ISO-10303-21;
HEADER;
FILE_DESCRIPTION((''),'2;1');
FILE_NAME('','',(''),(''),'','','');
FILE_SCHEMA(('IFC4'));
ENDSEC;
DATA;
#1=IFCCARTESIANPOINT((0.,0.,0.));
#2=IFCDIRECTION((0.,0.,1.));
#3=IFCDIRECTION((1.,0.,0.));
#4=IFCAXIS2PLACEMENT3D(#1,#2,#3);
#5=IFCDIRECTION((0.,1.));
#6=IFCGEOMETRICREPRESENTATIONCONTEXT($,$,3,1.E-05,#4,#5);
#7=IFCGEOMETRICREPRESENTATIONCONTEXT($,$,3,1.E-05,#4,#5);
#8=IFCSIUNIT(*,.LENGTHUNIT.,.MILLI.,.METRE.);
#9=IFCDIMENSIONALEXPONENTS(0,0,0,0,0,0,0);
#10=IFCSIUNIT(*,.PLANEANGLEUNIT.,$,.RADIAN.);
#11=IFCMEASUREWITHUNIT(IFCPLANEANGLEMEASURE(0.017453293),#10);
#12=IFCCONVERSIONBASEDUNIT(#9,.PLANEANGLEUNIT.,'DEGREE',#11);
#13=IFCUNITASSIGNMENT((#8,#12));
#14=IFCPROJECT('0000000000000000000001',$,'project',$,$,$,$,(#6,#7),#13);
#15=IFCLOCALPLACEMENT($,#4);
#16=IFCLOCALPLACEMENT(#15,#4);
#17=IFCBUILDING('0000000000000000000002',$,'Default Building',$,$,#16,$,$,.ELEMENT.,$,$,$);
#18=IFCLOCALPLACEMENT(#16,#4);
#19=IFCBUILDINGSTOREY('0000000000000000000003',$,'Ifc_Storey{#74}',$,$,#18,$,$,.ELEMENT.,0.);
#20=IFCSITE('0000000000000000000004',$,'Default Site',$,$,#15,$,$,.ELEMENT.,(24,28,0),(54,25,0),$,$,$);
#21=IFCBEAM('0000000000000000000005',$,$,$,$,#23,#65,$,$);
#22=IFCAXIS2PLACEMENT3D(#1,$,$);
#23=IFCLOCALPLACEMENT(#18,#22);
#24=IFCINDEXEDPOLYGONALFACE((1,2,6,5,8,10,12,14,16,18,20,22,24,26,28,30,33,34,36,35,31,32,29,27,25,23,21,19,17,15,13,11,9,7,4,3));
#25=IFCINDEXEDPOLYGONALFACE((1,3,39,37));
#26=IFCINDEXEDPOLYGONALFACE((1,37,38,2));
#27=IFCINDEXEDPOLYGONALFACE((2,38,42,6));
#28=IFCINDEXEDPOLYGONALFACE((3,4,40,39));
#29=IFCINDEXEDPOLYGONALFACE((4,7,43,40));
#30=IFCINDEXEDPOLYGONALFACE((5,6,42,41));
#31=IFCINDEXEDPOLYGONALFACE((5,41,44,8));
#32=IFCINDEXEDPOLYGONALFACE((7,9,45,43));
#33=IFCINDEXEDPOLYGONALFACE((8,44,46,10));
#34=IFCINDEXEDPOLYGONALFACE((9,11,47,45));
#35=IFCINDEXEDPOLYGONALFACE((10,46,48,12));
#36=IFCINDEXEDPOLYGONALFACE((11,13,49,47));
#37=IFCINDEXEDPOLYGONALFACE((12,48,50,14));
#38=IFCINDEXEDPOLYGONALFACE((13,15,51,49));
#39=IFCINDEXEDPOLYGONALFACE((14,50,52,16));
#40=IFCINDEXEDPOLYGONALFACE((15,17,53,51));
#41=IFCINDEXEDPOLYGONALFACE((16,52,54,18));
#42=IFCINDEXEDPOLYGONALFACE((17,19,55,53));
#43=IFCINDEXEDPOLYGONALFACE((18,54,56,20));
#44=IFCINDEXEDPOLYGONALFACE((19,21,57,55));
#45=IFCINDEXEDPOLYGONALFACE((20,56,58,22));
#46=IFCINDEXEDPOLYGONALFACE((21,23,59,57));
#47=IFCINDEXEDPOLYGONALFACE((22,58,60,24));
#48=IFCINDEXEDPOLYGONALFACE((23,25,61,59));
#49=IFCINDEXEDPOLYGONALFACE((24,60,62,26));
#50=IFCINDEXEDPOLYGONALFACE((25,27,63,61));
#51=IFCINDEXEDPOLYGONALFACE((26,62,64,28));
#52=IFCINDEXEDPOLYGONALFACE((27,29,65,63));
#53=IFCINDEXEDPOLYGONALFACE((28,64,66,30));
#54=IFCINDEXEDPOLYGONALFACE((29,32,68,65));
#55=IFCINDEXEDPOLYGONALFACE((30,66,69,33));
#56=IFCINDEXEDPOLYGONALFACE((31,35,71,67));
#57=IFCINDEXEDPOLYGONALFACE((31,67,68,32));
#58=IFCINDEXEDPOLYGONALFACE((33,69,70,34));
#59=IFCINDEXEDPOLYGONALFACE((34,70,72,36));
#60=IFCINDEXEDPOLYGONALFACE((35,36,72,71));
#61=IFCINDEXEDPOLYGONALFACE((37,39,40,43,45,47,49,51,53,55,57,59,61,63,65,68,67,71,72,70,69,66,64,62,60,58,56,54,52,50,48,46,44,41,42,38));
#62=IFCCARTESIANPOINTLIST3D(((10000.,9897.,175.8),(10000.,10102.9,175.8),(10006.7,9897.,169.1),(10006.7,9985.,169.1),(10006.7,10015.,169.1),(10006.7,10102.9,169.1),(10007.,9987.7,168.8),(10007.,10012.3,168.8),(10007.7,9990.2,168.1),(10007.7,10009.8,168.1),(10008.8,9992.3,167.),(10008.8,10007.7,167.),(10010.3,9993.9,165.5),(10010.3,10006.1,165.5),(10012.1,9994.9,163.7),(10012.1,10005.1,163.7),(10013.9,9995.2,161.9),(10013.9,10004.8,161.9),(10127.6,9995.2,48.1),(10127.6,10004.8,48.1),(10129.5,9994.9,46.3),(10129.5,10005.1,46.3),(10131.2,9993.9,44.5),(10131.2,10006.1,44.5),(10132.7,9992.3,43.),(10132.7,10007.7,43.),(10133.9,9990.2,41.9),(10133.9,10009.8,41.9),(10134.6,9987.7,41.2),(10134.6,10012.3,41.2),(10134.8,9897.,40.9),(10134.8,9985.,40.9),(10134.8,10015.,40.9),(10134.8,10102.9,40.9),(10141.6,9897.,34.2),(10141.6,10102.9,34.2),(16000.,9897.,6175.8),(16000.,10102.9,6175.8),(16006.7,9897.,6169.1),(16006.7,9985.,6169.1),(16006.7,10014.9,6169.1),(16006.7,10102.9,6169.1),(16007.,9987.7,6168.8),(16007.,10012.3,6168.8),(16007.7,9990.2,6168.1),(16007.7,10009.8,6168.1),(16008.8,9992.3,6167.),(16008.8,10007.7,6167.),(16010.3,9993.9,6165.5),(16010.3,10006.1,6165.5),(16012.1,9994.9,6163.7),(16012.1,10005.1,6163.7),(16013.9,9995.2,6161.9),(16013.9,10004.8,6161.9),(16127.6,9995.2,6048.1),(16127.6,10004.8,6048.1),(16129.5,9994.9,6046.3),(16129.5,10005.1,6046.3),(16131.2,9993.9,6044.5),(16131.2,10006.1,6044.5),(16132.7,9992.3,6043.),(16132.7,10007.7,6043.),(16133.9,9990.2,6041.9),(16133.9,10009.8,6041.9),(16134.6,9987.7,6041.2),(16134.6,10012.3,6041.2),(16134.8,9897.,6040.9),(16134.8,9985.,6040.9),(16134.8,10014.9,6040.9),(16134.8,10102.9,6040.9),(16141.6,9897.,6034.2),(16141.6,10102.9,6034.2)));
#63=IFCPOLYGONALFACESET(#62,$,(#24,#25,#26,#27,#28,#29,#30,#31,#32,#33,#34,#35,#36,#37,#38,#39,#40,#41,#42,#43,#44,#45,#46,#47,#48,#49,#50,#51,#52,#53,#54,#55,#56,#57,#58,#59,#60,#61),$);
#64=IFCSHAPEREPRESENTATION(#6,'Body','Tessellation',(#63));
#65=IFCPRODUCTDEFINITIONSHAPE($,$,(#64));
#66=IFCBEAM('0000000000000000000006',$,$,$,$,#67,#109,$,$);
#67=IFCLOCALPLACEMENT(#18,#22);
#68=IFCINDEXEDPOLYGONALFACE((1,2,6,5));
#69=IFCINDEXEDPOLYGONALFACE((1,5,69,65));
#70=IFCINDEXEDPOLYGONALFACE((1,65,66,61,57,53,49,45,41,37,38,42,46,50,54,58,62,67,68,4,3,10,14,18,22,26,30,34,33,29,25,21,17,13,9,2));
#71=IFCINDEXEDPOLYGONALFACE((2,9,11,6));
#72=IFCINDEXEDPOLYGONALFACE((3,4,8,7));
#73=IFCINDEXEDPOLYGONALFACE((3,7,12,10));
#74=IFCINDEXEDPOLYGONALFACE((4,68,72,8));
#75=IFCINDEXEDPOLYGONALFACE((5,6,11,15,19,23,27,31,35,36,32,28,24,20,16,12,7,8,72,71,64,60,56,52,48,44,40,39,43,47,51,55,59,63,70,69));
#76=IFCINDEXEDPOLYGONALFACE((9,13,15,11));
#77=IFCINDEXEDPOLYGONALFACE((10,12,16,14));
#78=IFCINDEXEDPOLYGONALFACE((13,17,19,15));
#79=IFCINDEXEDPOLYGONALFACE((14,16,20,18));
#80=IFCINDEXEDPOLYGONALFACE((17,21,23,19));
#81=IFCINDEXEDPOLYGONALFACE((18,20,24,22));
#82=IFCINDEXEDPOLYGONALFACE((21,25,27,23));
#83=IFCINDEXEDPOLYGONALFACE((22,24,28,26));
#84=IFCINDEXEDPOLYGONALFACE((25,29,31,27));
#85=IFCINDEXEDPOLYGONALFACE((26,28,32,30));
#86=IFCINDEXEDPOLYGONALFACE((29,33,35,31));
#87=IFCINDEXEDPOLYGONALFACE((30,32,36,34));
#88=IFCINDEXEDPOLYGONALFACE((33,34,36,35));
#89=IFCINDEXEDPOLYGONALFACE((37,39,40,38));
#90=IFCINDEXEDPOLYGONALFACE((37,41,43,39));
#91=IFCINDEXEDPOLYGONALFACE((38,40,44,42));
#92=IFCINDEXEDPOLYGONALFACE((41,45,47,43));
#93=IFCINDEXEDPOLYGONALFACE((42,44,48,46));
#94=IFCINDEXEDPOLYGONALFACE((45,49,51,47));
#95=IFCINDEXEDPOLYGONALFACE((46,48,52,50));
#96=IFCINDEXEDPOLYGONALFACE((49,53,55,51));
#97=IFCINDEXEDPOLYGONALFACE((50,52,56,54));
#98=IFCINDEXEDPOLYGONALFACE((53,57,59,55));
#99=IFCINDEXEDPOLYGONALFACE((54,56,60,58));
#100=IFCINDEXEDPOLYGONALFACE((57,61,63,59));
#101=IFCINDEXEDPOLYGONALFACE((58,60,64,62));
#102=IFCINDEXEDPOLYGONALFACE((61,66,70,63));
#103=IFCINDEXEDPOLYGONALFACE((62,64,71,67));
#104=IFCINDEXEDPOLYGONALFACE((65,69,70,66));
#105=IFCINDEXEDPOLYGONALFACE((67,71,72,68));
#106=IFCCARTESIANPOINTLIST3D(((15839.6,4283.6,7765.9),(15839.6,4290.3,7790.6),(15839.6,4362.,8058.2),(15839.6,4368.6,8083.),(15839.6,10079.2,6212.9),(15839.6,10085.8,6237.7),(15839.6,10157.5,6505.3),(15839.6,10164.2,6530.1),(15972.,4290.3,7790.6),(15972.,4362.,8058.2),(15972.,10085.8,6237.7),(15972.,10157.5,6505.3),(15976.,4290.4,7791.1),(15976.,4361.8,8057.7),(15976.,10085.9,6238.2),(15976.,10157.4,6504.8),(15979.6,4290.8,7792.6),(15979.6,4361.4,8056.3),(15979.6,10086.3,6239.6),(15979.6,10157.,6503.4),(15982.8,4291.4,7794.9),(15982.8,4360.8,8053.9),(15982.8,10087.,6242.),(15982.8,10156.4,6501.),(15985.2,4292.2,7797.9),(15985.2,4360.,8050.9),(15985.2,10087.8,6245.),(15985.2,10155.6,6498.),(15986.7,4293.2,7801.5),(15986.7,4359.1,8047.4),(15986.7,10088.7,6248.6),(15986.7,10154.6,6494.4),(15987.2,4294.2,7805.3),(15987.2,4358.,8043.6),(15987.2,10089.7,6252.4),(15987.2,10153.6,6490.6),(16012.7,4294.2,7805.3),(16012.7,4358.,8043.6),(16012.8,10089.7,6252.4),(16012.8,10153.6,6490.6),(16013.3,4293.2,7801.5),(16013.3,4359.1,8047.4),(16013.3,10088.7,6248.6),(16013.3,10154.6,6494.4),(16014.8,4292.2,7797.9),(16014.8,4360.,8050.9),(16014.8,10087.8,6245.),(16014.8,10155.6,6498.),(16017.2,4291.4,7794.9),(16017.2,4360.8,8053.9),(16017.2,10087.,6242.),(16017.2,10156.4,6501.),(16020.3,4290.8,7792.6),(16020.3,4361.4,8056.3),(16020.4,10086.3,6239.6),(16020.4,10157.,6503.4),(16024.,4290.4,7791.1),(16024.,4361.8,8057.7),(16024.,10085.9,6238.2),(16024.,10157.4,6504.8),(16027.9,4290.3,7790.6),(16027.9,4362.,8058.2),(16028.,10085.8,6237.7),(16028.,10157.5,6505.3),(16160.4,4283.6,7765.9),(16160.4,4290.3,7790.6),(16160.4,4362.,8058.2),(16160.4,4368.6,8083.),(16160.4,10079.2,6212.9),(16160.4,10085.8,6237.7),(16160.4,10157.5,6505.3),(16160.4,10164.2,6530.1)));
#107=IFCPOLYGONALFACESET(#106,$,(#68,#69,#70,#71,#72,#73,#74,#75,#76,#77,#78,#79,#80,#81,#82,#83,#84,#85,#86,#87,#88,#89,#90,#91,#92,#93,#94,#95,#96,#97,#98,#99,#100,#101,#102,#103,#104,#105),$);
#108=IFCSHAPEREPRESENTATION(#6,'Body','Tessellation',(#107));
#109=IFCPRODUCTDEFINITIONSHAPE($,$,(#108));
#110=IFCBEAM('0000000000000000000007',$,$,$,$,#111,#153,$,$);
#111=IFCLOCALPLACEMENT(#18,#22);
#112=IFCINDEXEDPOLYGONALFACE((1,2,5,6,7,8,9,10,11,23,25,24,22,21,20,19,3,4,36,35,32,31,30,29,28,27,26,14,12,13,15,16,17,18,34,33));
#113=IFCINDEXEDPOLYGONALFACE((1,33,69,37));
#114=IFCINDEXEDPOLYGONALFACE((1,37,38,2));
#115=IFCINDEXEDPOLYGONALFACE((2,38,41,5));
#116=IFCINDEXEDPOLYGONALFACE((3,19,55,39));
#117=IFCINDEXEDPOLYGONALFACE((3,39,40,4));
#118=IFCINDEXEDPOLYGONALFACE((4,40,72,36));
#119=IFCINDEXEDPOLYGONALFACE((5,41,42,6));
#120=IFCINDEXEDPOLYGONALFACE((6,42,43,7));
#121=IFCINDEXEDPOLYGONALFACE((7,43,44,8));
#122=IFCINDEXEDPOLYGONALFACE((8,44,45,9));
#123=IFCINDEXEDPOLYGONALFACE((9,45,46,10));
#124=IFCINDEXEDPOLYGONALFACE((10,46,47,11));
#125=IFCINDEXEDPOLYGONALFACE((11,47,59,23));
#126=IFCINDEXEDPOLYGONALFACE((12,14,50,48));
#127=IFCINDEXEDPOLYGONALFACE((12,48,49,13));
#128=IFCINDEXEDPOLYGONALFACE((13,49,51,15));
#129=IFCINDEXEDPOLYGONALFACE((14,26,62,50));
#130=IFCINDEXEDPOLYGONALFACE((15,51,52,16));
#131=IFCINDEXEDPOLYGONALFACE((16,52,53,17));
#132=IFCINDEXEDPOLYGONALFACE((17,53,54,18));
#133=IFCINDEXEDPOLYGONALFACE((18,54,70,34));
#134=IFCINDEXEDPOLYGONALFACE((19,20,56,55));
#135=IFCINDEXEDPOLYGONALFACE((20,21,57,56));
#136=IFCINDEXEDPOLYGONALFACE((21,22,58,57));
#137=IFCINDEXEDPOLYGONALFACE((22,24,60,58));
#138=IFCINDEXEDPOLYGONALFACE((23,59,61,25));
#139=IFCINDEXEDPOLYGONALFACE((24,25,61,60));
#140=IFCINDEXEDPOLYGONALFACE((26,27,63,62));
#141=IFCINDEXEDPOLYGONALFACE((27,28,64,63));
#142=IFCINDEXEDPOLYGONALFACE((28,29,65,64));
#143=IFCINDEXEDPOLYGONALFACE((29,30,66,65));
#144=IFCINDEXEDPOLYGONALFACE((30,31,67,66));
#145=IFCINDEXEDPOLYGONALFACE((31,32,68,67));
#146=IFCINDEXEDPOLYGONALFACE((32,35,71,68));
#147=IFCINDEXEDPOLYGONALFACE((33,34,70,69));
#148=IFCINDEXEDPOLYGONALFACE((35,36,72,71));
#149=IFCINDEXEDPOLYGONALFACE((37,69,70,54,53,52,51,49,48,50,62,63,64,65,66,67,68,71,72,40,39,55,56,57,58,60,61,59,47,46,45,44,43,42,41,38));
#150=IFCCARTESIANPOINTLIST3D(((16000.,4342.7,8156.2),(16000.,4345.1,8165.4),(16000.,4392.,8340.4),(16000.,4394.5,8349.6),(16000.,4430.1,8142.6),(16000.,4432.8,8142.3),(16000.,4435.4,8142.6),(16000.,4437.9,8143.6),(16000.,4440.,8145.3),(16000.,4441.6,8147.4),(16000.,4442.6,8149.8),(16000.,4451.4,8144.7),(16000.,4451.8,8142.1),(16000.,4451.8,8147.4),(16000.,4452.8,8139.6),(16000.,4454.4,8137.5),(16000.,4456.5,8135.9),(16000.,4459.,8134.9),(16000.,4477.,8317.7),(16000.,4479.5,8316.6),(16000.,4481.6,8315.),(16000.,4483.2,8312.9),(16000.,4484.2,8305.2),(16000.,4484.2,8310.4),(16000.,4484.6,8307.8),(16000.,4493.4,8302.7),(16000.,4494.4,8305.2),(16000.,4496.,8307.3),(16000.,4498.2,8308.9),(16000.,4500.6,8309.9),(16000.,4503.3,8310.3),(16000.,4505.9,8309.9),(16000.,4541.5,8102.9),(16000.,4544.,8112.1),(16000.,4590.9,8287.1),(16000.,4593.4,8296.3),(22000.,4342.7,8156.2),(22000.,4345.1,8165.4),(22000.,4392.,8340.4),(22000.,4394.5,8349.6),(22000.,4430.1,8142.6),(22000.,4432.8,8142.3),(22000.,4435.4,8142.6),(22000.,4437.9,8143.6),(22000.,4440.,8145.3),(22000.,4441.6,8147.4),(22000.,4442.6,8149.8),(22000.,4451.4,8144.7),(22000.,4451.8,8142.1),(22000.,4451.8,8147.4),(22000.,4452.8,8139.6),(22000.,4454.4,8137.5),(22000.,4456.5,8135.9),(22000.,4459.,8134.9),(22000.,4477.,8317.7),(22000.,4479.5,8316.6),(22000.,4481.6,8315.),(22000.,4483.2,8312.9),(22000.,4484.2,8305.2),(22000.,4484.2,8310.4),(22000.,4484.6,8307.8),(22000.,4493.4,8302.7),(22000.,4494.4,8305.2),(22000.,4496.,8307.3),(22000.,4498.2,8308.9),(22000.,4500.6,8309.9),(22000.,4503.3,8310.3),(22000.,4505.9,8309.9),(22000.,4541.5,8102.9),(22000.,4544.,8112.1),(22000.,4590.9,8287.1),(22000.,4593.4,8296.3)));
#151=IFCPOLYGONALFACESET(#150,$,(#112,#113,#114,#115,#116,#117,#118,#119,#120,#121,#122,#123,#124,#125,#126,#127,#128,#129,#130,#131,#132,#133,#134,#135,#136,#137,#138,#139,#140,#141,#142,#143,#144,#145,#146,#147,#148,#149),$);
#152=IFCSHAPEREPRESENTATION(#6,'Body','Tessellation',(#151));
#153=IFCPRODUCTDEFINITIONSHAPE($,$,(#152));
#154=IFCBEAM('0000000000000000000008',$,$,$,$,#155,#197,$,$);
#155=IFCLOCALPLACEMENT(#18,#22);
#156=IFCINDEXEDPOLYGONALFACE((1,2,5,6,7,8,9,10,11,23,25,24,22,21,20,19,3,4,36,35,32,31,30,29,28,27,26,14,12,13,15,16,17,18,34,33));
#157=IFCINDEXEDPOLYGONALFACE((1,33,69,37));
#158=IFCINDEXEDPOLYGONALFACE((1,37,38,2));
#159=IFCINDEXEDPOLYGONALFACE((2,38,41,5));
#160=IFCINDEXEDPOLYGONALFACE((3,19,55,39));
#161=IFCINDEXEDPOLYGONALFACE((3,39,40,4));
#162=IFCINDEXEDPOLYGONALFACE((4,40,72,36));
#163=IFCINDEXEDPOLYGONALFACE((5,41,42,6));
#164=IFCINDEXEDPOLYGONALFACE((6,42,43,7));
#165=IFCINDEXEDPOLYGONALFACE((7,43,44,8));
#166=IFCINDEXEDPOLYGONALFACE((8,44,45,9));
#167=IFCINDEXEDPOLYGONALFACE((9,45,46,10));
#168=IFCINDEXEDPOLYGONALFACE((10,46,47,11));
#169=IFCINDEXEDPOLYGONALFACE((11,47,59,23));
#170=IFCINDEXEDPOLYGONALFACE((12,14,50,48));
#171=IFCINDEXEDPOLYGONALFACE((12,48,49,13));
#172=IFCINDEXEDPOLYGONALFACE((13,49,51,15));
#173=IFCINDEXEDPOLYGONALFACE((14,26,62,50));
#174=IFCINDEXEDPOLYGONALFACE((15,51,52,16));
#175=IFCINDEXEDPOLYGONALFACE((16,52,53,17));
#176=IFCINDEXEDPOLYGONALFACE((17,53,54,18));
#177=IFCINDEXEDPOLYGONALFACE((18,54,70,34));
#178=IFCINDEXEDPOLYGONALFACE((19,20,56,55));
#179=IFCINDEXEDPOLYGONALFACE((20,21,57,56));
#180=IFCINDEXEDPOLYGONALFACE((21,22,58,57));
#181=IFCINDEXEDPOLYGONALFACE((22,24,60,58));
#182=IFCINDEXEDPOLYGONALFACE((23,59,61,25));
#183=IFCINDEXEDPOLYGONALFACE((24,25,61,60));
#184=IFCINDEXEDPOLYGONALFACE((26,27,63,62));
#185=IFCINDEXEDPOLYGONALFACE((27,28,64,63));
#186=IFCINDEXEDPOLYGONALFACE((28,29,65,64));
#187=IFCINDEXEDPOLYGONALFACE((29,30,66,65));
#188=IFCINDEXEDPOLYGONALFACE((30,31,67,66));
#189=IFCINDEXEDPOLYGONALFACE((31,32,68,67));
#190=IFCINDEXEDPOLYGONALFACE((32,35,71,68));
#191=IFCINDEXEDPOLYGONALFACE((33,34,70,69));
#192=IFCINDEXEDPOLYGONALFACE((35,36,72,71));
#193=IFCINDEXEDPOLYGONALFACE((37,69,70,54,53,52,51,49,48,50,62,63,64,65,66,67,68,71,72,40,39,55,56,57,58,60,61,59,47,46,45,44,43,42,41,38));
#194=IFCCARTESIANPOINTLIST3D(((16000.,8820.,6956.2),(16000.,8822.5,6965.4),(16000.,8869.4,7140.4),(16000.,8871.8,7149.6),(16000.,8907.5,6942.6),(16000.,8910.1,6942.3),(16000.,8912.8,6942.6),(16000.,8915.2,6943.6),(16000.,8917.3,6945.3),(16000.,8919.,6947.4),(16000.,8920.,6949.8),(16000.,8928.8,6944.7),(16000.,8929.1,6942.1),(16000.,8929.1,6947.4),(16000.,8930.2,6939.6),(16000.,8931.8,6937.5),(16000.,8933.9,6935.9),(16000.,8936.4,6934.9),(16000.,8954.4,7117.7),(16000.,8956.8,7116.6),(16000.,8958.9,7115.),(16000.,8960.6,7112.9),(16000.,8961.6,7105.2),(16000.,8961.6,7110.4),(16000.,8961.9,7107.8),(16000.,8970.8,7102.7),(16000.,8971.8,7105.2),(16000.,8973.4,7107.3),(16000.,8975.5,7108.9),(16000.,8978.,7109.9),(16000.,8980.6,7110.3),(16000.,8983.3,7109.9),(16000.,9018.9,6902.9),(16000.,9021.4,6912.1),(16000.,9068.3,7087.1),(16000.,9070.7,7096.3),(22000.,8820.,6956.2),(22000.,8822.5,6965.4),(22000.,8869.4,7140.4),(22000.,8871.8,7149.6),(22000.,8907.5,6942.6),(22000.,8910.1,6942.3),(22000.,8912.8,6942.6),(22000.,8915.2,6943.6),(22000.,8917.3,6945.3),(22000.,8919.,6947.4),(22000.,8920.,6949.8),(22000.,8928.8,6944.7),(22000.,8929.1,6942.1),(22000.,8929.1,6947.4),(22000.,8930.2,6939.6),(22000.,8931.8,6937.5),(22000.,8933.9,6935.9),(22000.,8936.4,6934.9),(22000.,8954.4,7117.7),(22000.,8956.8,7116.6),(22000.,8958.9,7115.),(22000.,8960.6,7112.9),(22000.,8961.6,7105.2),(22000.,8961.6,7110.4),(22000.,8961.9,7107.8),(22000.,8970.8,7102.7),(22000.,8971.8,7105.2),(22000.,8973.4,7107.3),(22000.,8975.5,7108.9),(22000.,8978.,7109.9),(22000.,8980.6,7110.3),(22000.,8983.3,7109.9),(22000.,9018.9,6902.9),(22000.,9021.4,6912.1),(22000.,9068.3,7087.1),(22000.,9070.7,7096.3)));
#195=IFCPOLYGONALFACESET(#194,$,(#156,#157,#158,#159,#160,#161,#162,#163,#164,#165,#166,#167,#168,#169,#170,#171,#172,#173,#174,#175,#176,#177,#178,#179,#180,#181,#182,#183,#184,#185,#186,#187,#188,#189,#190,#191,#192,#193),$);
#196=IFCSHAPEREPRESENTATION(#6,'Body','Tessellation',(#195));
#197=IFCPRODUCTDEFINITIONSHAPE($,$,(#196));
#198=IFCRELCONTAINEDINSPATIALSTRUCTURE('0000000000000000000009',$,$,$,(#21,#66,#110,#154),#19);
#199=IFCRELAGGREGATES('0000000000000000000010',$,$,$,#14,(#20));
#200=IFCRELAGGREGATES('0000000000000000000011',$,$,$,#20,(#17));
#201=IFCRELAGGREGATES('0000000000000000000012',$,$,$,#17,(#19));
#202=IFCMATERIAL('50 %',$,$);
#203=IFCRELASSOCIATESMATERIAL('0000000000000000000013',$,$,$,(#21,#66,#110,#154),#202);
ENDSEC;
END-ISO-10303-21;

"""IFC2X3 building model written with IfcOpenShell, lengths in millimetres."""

from ifc_helpers import new_model, entity, si_unit, converted_unit, direction, frame, origin_with_axes, origin_2d_with_axis, place, context, project, spatial, i_section, extrude, material, element, save


model = new_model("IFC2X3")

# Units and contexts
context_of_model_1 = context(None, 3, precision=1e-05, world=origin_with_axes(), true_north=direction((0.0, 1.0)))
context_of_model_2 = context(None, 3, precision=1e-05, world=origin_with_axes(), true_north=direction((0.0, 1.0)))
ifc_project = project(units=[si_unit("LENGTHUNIT", "METRE", prefix="MILLI"), converted_unit("PLANEANGLEUNIT", "DEGREE", entity("IfcPlaneAngleMeasure", 0.017453293), si_unit("PLANEANGLEUNIT", "RADIAN"), dimensions=[0, 0, 0, 0, 0, 0, 0])], contexts=[context_of_model_1, context_of_model_2])

# Site, building, storey
site_placement = place(None, origin_with_axes())
site = spatial("IfcSite", under=ifc_project, at=site_placement, Name="Default Site", CompositionType="ELEMENT", RefLatitude=(24, 28, 0), RefLongitude=(54, 25, 0))
building_placement = place(site_placement, origin_with_axes())
building = spatial("IfcBuilding", under=site, at=building_placement, Name="Default Building", CompositionType="ELEMENT")
storey_placement = place(building_placement, origin_with_axes())
storey = spatial("IfcBuildingStorey", under=building, at=storey_placement, Name="Ifc_Storey{#74}", CompositionType="ELEMENT", Elevation=0.0)

# Shared definitions
ifc_material_1 = material(Name="50 %")

# Beams
beam_1_placement = place(storey_placement, frame((10070.8, 10000.0, 105.0), z_axis=(0.0, 0.0, 1.0), x_axis=(1.0, 0.0, 0.0)))
element("IfcBeam", 1, at=beam_1_placement, inside=storey, material=ifc_material_1, context=context_of_model_1, shape_type="SweptSolid", body=[
    extrude(i_section(OverallWidth=205.9, OverallDepth=200.2, WebThickness=9.5, FlangeThickness=9.5, FilletRadius=10.2, at=origin_2d_with_axis()), frame((0.0, 0.0, 0.0), z_axis=(0.707107, 0.0, 0.707107), x_axis=(0.0, 1.0, 0.0)), (0.0, 0.0, 1.0), 8485.3),
])
beam_2_placement = place(storey_placement, frame((16000.0, 10121.7, 6371.5), z_axis=(0.0, 0.0, 1.0), x_axis=(0.0, -1.0, 0.0)))
element("IfcBeam", 2, at=beam_2_placement, inside=storey, material=ifc_material_1, context=context_of_model_1, shape_type="SweptSolid", body=[
    extrude(i_section(OverallWidth=320.9, OverallDepth=328.3, WebThickness=25.5, FlangeThickness=25.6, FilletRadius=15.2, at=origin_2d_with_axis()), frame((0.0, 0.0, 0.0), z_axis=(0.965926, 0.0, 0.258819), x_axis=(0.0, 1.0, 0.0)), (0.0, 0.0, 1.0), 6000.0),
])
for number, where, z_axis, x_axis in (
    (3, (16000.0, 4468.0, 8226.3), (0.0, 0.258819, 0.965926), (1.0, 0.0, 0.0)),
    (4, (16000.0, 8945.4, 7026.3), (0.0, 0.258819, 0.965926), (1.0, 0.0, 0.0)),
):
    element("IfcBeam", number, at=place(storey_placement, frame(where, z_axis=z_axis, x_axis=x_axis)), inside=storey, material=ifc_material_1, context=context_of_model_1, shape_type="SweptSolid", body=[
        extrude(i_section(OverallWidth=205.9, OverallDepth=200.2, WebThickness=9.5, FlangeThickness=9.5, FilletRadius=10.2, at=origin_2d_with_axis()), frame((0.0, 0.0, 0.0), z_axis=(1.0, 0.0, 0.0), x_axis=(0.0, 1.0, 0.0)), (0.0, 0.0, 1.0), 6000.0),
    ])

save(model, "model.ifc")
